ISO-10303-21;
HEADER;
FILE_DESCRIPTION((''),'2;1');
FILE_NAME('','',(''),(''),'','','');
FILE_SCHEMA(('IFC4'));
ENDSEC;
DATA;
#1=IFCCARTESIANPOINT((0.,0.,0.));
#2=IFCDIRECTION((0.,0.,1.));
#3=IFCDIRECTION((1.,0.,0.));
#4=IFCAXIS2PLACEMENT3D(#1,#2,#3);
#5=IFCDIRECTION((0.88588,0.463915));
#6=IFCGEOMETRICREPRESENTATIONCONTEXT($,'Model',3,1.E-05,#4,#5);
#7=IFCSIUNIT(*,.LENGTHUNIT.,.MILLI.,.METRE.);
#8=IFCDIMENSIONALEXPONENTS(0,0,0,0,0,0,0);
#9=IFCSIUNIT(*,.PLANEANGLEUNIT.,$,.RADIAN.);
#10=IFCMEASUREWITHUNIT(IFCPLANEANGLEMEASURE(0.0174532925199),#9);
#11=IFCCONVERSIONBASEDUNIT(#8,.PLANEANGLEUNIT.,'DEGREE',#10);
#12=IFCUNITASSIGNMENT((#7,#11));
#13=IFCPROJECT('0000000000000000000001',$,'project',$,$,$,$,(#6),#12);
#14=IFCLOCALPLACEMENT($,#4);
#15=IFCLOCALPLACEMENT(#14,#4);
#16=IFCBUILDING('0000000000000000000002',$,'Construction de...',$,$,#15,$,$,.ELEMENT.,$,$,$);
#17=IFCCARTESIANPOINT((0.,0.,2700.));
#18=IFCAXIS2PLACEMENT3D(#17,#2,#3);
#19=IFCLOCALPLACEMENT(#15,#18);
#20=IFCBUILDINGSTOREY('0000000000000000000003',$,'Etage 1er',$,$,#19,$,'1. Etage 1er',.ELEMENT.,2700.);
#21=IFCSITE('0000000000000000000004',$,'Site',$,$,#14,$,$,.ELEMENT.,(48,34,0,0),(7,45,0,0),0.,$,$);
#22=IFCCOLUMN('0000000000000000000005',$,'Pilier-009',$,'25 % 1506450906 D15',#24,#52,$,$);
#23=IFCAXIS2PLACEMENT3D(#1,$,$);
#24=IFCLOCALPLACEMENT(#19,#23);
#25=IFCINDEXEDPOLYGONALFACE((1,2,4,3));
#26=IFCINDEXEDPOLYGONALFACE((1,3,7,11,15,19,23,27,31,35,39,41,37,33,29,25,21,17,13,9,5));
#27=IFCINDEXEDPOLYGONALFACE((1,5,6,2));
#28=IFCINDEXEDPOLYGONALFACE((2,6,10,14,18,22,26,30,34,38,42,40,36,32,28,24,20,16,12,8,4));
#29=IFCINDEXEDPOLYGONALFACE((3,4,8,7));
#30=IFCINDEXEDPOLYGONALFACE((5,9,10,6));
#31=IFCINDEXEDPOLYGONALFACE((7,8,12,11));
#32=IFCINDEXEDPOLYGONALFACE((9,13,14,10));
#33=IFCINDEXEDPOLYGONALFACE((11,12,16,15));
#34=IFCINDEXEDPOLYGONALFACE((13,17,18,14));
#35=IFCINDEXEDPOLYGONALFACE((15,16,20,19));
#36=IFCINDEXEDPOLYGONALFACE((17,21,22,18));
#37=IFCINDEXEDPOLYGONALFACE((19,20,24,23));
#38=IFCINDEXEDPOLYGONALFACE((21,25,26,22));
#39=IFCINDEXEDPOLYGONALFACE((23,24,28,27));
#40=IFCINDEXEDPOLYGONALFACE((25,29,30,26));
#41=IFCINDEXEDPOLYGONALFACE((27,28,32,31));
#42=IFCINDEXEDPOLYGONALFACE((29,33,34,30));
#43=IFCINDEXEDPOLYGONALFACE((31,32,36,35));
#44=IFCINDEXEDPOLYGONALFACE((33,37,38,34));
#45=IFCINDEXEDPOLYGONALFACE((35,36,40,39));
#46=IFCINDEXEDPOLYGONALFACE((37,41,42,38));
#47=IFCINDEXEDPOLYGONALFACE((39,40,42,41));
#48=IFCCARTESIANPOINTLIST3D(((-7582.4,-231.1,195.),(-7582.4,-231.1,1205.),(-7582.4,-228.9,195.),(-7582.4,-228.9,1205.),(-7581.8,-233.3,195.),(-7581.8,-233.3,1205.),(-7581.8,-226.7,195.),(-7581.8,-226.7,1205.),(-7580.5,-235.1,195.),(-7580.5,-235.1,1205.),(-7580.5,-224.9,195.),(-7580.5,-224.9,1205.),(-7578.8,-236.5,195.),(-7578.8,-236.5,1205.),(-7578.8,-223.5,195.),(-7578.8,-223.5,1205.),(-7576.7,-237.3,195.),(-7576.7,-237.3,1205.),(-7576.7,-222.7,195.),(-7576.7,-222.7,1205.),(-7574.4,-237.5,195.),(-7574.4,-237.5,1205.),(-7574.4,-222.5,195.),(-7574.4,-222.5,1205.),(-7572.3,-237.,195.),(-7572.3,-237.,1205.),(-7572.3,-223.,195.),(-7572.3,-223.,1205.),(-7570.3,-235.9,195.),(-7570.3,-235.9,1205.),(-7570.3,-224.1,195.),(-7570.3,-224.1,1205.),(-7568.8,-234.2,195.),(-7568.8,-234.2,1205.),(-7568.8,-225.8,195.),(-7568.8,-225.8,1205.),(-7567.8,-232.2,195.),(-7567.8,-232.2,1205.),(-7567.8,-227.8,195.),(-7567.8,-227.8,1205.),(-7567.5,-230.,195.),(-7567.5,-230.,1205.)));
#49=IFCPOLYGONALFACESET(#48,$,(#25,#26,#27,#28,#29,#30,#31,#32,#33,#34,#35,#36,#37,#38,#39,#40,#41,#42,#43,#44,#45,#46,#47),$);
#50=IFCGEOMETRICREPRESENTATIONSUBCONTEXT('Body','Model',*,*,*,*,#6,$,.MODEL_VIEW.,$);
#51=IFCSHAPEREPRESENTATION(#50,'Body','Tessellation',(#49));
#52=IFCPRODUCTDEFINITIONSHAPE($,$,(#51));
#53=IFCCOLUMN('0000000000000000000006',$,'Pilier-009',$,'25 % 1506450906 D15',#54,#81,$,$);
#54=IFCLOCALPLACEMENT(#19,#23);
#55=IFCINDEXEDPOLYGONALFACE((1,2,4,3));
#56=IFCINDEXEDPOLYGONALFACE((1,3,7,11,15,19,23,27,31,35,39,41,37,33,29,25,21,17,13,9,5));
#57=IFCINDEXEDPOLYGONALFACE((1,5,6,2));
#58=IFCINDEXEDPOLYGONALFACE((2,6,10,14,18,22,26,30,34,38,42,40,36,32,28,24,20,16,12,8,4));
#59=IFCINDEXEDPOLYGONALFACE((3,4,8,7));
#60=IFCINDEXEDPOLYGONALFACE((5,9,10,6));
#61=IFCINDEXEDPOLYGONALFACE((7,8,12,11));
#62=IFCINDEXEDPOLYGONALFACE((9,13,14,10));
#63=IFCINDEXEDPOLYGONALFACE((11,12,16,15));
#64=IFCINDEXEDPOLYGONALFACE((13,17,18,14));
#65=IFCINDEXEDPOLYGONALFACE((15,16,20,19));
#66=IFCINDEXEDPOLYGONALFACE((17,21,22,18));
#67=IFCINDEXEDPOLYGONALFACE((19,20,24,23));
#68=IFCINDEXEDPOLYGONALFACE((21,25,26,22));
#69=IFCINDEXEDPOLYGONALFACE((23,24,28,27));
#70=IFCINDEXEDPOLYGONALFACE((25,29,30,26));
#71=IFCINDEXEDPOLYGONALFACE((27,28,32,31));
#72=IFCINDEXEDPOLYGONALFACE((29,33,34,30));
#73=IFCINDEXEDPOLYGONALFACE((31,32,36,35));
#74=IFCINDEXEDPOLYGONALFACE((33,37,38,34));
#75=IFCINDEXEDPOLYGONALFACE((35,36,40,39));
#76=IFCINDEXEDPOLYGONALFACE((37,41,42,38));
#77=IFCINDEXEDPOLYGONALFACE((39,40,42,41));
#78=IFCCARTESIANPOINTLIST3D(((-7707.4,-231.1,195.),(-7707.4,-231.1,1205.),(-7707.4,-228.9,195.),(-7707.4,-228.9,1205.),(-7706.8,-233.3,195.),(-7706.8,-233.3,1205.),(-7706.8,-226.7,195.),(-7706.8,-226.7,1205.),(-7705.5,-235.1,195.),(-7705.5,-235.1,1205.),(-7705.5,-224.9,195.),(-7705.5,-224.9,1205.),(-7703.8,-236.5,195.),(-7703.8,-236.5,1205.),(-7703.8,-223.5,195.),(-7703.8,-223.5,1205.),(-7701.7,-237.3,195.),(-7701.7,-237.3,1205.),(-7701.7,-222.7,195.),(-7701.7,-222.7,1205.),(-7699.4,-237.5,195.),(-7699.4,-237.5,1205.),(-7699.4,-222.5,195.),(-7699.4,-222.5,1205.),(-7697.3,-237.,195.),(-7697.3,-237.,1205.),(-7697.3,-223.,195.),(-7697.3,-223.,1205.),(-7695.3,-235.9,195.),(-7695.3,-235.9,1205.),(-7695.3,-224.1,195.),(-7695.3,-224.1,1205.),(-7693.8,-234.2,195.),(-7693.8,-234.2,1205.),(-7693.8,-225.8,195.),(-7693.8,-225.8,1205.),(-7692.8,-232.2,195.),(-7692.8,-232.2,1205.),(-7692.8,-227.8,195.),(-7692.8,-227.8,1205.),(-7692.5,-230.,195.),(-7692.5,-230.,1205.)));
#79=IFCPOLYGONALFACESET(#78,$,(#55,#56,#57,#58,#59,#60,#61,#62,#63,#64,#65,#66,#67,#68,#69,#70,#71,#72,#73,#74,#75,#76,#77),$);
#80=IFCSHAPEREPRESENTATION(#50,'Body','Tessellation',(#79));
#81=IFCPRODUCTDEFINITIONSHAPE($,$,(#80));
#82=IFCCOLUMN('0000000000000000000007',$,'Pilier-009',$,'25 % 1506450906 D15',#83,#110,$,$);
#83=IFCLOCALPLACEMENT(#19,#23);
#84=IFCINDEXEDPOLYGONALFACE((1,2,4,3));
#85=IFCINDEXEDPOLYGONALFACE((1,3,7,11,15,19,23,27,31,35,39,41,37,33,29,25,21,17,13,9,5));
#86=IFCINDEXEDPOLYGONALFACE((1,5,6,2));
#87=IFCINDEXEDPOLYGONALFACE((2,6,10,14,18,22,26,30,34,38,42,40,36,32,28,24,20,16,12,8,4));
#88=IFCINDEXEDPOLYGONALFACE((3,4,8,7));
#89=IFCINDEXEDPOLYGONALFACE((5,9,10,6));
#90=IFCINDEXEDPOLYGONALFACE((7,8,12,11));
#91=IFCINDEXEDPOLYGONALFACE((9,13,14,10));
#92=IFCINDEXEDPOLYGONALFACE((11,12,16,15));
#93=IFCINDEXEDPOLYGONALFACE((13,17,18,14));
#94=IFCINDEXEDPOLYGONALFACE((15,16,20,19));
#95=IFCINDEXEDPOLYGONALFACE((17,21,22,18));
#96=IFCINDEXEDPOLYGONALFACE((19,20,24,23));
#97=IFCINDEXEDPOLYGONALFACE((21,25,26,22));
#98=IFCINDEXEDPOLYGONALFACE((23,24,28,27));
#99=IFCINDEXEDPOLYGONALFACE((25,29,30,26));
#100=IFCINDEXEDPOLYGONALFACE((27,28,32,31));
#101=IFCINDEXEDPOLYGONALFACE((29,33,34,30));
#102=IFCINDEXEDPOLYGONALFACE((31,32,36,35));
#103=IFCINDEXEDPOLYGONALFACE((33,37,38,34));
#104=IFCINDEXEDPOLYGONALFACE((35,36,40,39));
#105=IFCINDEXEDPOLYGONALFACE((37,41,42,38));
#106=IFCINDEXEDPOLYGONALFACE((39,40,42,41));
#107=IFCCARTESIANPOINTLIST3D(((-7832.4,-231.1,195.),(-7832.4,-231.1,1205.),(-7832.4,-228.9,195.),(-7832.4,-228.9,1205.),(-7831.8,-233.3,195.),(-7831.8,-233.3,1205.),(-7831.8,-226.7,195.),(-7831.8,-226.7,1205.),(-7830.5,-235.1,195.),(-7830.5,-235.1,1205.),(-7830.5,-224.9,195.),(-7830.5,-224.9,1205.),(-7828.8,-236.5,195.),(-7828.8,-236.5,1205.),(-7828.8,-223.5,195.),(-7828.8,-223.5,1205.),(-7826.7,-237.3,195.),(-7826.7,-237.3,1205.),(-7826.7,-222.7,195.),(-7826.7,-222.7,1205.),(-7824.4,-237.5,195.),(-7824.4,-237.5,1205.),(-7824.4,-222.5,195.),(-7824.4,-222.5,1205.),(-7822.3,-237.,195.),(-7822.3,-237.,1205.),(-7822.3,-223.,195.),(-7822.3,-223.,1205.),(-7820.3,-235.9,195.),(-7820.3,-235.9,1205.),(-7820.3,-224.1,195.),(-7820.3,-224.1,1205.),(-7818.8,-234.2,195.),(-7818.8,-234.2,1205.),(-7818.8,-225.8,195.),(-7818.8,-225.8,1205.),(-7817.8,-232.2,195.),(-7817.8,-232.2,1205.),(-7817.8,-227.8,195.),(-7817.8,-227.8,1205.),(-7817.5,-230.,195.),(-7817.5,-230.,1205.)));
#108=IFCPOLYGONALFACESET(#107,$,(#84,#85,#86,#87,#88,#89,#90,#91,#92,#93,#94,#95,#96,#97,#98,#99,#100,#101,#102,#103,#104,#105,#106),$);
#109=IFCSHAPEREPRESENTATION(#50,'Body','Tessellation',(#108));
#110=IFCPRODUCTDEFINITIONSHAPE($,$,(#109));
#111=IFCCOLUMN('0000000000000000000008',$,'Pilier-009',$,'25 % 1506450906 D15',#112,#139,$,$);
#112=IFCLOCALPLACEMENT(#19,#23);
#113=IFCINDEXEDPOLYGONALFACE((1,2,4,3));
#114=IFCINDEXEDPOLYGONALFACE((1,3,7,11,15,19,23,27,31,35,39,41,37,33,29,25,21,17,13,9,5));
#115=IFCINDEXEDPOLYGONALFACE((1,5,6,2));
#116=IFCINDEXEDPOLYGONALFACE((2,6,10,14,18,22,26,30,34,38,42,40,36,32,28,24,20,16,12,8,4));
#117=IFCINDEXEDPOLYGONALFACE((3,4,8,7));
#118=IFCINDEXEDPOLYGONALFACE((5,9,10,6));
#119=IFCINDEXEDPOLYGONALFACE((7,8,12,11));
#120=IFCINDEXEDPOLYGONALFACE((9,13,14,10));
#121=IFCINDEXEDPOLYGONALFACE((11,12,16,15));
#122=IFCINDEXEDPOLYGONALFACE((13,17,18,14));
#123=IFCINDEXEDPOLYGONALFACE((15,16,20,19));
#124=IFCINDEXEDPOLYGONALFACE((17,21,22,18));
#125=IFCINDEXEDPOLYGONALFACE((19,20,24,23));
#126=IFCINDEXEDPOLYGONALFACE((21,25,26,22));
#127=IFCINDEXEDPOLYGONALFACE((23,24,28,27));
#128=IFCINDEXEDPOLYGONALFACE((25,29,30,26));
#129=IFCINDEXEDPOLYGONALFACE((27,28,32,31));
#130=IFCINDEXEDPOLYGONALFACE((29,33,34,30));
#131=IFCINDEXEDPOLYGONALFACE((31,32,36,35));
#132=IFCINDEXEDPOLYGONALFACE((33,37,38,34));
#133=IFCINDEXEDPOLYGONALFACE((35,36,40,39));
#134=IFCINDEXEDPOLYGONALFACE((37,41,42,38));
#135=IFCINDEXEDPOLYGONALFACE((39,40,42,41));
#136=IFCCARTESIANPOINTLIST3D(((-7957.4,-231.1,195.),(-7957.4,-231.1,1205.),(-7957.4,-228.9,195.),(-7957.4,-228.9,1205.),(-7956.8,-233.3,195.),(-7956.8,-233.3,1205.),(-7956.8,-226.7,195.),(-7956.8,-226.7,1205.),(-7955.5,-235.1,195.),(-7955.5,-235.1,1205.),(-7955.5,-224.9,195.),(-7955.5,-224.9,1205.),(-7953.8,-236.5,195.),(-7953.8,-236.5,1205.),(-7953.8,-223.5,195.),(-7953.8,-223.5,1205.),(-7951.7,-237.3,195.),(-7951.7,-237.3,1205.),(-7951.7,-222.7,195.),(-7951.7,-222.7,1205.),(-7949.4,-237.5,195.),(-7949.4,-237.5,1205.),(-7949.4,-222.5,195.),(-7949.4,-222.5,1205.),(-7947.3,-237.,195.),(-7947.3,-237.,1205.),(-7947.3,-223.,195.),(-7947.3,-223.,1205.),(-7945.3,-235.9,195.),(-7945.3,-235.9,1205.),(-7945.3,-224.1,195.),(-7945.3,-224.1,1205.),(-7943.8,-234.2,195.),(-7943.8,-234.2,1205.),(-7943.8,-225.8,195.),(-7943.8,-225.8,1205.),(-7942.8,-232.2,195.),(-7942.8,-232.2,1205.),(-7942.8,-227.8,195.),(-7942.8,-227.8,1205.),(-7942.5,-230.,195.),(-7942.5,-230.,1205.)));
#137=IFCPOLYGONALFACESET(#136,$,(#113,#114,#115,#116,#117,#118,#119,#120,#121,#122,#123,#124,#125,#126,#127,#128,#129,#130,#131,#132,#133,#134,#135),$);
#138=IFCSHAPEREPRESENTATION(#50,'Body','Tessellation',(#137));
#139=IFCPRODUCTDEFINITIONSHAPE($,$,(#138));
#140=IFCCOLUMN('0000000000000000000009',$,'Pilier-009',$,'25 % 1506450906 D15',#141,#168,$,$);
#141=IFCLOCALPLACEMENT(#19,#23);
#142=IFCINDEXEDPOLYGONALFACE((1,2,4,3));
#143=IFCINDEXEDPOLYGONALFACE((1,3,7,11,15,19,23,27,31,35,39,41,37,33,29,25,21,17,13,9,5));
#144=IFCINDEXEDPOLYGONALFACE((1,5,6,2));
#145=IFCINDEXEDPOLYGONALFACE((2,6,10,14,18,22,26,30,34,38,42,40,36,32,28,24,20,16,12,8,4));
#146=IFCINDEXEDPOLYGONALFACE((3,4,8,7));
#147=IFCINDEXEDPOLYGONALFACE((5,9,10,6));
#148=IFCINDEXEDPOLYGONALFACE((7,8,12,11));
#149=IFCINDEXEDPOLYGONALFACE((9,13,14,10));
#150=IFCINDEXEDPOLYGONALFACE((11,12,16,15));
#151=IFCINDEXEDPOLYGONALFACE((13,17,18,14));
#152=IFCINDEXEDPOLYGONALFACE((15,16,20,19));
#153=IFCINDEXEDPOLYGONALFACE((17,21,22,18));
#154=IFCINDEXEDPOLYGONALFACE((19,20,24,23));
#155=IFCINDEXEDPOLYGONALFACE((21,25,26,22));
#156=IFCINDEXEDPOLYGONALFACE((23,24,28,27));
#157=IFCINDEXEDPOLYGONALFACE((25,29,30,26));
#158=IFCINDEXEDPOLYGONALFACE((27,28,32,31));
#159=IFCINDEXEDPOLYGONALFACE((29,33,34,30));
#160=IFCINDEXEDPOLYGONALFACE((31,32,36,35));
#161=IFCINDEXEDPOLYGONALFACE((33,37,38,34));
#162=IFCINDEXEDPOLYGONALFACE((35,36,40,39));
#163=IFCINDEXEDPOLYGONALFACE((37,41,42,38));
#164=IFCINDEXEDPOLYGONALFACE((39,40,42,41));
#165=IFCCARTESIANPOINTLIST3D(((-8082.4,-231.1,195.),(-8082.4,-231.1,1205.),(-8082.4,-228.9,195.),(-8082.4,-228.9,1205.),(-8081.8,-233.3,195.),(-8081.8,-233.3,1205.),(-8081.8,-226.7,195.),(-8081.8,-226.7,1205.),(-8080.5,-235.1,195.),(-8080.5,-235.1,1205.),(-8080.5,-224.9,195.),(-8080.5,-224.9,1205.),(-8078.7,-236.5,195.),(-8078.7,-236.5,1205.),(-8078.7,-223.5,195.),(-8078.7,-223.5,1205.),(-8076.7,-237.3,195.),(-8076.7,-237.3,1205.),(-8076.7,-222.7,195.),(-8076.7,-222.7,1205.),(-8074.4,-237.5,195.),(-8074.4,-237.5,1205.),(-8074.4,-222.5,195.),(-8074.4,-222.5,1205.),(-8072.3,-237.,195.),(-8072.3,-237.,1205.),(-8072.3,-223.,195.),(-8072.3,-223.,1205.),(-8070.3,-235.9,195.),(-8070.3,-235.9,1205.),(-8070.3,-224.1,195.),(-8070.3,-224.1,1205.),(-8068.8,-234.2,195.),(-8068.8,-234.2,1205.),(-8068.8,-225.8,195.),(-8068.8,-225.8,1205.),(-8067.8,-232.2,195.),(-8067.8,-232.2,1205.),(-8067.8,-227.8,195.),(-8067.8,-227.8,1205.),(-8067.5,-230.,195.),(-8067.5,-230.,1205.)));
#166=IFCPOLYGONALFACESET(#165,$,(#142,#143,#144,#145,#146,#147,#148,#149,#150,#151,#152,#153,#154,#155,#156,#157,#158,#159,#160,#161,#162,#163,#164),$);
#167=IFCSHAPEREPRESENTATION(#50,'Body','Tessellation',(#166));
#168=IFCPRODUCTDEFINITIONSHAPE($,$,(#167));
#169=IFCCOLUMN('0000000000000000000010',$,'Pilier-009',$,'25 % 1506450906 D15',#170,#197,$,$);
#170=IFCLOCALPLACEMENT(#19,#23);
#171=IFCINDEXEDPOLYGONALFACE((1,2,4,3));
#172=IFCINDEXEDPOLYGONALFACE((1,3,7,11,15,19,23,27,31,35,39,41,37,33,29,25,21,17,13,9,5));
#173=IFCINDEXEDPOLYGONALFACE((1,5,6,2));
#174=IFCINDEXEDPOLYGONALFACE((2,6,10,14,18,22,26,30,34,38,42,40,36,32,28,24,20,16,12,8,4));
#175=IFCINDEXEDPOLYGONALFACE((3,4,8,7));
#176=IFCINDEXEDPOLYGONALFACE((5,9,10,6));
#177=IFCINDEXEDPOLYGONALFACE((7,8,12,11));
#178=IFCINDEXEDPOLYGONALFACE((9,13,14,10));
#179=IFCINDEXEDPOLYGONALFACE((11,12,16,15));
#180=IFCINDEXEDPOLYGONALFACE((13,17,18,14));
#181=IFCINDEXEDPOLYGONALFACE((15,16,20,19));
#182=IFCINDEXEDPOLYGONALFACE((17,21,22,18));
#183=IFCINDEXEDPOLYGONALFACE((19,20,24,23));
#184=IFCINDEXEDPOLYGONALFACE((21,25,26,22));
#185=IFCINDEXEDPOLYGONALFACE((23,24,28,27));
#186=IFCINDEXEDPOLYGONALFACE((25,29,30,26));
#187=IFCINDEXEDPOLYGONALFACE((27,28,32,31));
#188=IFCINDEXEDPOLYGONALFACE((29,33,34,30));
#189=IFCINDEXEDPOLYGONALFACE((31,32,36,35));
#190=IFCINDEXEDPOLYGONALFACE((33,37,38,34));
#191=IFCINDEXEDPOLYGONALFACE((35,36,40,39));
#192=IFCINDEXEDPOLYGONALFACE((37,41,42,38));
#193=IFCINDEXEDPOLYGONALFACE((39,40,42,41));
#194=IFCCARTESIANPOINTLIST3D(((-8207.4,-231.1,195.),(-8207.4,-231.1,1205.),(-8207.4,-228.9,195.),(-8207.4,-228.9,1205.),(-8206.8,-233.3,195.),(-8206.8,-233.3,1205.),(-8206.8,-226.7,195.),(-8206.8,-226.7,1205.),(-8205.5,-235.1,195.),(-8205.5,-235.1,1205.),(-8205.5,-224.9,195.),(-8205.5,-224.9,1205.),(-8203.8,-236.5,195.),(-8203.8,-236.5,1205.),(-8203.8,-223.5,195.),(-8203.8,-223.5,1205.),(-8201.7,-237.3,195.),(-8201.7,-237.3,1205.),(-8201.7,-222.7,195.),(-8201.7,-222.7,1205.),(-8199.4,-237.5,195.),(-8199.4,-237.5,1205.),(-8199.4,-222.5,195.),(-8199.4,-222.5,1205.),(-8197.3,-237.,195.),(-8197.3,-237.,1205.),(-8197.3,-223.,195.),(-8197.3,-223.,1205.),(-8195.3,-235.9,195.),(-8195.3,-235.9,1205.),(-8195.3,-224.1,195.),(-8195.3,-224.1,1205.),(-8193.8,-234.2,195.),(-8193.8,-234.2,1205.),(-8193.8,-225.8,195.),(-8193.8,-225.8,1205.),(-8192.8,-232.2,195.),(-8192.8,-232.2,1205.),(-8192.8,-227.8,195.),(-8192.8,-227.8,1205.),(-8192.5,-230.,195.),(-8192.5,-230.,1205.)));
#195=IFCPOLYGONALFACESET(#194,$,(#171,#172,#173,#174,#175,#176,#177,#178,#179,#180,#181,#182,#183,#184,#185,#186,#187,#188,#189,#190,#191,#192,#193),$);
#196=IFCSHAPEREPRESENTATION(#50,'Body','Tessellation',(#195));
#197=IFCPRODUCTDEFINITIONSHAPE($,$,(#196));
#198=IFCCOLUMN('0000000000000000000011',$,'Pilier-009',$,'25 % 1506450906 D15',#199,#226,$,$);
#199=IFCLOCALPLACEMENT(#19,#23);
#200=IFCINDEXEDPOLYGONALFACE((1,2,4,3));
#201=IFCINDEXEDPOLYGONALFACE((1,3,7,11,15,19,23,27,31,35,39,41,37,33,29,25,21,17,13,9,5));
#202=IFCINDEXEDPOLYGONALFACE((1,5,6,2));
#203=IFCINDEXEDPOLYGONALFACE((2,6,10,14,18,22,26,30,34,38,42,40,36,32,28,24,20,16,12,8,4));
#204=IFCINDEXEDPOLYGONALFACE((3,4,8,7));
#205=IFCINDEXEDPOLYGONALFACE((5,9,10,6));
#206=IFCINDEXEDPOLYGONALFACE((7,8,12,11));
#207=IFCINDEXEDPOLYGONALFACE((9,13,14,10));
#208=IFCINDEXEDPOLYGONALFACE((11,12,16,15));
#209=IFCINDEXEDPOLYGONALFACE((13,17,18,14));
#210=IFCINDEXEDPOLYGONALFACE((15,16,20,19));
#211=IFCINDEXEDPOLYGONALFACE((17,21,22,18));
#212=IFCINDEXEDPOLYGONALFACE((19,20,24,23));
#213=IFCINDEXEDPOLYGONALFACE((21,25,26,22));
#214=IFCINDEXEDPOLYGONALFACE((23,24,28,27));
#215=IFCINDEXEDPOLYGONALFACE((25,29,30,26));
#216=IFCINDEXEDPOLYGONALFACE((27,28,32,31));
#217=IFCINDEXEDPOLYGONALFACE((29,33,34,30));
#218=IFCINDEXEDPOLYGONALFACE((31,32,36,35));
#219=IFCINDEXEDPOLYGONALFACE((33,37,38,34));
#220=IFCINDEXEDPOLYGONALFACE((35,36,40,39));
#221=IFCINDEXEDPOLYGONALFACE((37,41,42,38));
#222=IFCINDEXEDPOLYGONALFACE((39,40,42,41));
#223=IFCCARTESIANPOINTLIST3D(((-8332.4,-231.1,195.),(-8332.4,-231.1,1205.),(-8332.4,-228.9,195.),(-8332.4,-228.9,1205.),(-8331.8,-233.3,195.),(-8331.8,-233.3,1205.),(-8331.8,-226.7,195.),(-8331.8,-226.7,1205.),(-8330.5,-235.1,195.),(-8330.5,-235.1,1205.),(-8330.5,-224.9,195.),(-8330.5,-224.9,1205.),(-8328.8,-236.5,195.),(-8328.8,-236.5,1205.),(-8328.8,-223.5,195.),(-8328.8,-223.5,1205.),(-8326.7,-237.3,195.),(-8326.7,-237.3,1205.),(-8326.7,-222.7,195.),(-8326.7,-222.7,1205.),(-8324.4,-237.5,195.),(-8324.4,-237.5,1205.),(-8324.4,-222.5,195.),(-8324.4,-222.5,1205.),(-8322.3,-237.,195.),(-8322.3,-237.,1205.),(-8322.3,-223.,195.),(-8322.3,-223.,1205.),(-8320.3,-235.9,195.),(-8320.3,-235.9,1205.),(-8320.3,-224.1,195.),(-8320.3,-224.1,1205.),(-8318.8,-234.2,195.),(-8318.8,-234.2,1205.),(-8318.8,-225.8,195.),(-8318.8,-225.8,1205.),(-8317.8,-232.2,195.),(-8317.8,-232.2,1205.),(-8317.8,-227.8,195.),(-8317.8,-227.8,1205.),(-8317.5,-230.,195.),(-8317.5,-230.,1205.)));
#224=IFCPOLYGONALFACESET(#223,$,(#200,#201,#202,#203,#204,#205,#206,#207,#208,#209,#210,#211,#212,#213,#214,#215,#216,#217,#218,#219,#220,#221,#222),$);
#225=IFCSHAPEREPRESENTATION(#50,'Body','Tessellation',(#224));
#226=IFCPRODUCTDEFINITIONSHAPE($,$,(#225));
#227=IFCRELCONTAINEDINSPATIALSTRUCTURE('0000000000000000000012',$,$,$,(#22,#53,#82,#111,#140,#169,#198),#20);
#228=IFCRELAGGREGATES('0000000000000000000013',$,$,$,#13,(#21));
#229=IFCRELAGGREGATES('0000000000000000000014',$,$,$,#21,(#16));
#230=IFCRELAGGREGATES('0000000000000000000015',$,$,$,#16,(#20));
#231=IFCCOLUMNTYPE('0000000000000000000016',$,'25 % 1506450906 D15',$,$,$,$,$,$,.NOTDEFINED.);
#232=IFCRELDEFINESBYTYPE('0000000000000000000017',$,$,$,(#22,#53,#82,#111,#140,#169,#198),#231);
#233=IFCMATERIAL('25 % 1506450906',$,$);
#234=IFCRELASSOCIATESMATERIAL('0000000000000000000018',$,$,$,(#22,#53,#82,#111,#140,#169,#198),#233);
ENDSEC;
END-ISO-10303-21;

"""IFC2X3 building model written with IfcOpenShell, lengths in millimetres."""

from ifc_helpers import new_model, entity, si_unit, converted_unit, direction, frame, origin_with_axes, origin_2d_with_axis, place, context, subcontext, project, spatial, circle, extrude, material, type_object, element, save


model = new_model("IFC2X3")

# Units and contexts
model_context = context("Model", 3, precision=1e-05, world=origin_with_axes(), true_north=direction((0.88588, 0.463915)))
body_context = subcontext(model_context, "Body", "Model", "MODEL_VIEW")
ifc_project = project(units=[si_unit("LENGTHUNIT", "METRE", prefix="MILLI"), converted_unit("PLANEANGLEUNIT", "DEGREE", entity("IfcPlaneAngleMeasure", 0.0174532925199), si_unit("PLANEANGLEUNIT", "RADIAN"), dimensions=[0, 0, 0, 0, 0, 0, 0])], contexts=[model_context])

# Site, building, storey
site_placement = place(None, origin_with_axes())
site = spatial("IfcSite", under=ifc_project, at=site_placement, Name="Site", CompositionType="ELEMENT", RefLatitude=(48, 34, 0, 0), RefLongitude=(7, 45, 0, 0), RefElevation=0.0)
building_placement = place(site_placement, origin_with_axes())
building = spatial("IfcBuilding", under=site, at=building_placement, Name="Construction de...", CompositionType="ELEMENT")
storey_placement = place(building_placement, frame((0.0, 0.0, 2700.0), z_axis=(0.0, 0.0, 1.0), x_axis=(1.0, 0.0, 0.0)))
storey = spatial("IfcBuildingStorey", under=building, at=storey_placement, Name="Etage 1er", LongName="1. Etage 1er", CompositionType="ELEMENT", Elevation=2700.0)

# Columns
ifc_material = material(Name="25 % 1506450906")
column_type = type_object("IfcColumnType", Name="25 % 1506450906 D15", PredefinedType="NOTDEFINED")
for number, where, z_axis, x_axis, name in (
    (1, (-7575.0, -230.0, 195.0), (0.0, 0.0, 1.0), (1.0, 0.0, 0.0), "Pilier-009"),
    (2, (-7700.0, -230.0, 195.0), (0.0, 0.0, 1.0), (1.0, 0.0, 0.0), "Pilier-009"),
    (3, (-7825.0, -230.0, 195.0), (0.0, 0.0, 1.0), (1.0, 0.0, 0.0), "Pilier-009"),
    (4, (-7950.0, -230.0, 195.0), (0.0, 0.0, 1.0), (1.0, 0.0, 0.0), "Pilier-009"),
    (5, (-8075.0, -230.0, 195.0), (0.0, 0.0, 1.0), (1.0, 0.0, 0.0), "Pilier-009"),
    (6, (-8200.0, -230.0, 195.0), (0.0, 0.0, 1.0), (1.0, 0.0, 0.0), "Pilier-009"),
    (7, (-8325.0, -230.0, 195.0), (0.0, 0.0, 1.0), (1.0, 0.0, 0.0), "Pilier-009"),
):
    element("IfcColumn", number, at=place(storey_placement, frame(where, z_axis=z_axis, x_axis=x_axis)), inside=storey, type_object=column_type, material=ifc_material, Name=name, ObjectType="25 % 1506450906 D15", context=body_context, shape_type="SweptSolid", body=[
        extrude(circle(Radius=7.5, at=origin_2d_with_axis()), origin_with_axes(), (0.0, 0.0, 1.0), 1010.0),
    ])

save(model, "model.ifc")
